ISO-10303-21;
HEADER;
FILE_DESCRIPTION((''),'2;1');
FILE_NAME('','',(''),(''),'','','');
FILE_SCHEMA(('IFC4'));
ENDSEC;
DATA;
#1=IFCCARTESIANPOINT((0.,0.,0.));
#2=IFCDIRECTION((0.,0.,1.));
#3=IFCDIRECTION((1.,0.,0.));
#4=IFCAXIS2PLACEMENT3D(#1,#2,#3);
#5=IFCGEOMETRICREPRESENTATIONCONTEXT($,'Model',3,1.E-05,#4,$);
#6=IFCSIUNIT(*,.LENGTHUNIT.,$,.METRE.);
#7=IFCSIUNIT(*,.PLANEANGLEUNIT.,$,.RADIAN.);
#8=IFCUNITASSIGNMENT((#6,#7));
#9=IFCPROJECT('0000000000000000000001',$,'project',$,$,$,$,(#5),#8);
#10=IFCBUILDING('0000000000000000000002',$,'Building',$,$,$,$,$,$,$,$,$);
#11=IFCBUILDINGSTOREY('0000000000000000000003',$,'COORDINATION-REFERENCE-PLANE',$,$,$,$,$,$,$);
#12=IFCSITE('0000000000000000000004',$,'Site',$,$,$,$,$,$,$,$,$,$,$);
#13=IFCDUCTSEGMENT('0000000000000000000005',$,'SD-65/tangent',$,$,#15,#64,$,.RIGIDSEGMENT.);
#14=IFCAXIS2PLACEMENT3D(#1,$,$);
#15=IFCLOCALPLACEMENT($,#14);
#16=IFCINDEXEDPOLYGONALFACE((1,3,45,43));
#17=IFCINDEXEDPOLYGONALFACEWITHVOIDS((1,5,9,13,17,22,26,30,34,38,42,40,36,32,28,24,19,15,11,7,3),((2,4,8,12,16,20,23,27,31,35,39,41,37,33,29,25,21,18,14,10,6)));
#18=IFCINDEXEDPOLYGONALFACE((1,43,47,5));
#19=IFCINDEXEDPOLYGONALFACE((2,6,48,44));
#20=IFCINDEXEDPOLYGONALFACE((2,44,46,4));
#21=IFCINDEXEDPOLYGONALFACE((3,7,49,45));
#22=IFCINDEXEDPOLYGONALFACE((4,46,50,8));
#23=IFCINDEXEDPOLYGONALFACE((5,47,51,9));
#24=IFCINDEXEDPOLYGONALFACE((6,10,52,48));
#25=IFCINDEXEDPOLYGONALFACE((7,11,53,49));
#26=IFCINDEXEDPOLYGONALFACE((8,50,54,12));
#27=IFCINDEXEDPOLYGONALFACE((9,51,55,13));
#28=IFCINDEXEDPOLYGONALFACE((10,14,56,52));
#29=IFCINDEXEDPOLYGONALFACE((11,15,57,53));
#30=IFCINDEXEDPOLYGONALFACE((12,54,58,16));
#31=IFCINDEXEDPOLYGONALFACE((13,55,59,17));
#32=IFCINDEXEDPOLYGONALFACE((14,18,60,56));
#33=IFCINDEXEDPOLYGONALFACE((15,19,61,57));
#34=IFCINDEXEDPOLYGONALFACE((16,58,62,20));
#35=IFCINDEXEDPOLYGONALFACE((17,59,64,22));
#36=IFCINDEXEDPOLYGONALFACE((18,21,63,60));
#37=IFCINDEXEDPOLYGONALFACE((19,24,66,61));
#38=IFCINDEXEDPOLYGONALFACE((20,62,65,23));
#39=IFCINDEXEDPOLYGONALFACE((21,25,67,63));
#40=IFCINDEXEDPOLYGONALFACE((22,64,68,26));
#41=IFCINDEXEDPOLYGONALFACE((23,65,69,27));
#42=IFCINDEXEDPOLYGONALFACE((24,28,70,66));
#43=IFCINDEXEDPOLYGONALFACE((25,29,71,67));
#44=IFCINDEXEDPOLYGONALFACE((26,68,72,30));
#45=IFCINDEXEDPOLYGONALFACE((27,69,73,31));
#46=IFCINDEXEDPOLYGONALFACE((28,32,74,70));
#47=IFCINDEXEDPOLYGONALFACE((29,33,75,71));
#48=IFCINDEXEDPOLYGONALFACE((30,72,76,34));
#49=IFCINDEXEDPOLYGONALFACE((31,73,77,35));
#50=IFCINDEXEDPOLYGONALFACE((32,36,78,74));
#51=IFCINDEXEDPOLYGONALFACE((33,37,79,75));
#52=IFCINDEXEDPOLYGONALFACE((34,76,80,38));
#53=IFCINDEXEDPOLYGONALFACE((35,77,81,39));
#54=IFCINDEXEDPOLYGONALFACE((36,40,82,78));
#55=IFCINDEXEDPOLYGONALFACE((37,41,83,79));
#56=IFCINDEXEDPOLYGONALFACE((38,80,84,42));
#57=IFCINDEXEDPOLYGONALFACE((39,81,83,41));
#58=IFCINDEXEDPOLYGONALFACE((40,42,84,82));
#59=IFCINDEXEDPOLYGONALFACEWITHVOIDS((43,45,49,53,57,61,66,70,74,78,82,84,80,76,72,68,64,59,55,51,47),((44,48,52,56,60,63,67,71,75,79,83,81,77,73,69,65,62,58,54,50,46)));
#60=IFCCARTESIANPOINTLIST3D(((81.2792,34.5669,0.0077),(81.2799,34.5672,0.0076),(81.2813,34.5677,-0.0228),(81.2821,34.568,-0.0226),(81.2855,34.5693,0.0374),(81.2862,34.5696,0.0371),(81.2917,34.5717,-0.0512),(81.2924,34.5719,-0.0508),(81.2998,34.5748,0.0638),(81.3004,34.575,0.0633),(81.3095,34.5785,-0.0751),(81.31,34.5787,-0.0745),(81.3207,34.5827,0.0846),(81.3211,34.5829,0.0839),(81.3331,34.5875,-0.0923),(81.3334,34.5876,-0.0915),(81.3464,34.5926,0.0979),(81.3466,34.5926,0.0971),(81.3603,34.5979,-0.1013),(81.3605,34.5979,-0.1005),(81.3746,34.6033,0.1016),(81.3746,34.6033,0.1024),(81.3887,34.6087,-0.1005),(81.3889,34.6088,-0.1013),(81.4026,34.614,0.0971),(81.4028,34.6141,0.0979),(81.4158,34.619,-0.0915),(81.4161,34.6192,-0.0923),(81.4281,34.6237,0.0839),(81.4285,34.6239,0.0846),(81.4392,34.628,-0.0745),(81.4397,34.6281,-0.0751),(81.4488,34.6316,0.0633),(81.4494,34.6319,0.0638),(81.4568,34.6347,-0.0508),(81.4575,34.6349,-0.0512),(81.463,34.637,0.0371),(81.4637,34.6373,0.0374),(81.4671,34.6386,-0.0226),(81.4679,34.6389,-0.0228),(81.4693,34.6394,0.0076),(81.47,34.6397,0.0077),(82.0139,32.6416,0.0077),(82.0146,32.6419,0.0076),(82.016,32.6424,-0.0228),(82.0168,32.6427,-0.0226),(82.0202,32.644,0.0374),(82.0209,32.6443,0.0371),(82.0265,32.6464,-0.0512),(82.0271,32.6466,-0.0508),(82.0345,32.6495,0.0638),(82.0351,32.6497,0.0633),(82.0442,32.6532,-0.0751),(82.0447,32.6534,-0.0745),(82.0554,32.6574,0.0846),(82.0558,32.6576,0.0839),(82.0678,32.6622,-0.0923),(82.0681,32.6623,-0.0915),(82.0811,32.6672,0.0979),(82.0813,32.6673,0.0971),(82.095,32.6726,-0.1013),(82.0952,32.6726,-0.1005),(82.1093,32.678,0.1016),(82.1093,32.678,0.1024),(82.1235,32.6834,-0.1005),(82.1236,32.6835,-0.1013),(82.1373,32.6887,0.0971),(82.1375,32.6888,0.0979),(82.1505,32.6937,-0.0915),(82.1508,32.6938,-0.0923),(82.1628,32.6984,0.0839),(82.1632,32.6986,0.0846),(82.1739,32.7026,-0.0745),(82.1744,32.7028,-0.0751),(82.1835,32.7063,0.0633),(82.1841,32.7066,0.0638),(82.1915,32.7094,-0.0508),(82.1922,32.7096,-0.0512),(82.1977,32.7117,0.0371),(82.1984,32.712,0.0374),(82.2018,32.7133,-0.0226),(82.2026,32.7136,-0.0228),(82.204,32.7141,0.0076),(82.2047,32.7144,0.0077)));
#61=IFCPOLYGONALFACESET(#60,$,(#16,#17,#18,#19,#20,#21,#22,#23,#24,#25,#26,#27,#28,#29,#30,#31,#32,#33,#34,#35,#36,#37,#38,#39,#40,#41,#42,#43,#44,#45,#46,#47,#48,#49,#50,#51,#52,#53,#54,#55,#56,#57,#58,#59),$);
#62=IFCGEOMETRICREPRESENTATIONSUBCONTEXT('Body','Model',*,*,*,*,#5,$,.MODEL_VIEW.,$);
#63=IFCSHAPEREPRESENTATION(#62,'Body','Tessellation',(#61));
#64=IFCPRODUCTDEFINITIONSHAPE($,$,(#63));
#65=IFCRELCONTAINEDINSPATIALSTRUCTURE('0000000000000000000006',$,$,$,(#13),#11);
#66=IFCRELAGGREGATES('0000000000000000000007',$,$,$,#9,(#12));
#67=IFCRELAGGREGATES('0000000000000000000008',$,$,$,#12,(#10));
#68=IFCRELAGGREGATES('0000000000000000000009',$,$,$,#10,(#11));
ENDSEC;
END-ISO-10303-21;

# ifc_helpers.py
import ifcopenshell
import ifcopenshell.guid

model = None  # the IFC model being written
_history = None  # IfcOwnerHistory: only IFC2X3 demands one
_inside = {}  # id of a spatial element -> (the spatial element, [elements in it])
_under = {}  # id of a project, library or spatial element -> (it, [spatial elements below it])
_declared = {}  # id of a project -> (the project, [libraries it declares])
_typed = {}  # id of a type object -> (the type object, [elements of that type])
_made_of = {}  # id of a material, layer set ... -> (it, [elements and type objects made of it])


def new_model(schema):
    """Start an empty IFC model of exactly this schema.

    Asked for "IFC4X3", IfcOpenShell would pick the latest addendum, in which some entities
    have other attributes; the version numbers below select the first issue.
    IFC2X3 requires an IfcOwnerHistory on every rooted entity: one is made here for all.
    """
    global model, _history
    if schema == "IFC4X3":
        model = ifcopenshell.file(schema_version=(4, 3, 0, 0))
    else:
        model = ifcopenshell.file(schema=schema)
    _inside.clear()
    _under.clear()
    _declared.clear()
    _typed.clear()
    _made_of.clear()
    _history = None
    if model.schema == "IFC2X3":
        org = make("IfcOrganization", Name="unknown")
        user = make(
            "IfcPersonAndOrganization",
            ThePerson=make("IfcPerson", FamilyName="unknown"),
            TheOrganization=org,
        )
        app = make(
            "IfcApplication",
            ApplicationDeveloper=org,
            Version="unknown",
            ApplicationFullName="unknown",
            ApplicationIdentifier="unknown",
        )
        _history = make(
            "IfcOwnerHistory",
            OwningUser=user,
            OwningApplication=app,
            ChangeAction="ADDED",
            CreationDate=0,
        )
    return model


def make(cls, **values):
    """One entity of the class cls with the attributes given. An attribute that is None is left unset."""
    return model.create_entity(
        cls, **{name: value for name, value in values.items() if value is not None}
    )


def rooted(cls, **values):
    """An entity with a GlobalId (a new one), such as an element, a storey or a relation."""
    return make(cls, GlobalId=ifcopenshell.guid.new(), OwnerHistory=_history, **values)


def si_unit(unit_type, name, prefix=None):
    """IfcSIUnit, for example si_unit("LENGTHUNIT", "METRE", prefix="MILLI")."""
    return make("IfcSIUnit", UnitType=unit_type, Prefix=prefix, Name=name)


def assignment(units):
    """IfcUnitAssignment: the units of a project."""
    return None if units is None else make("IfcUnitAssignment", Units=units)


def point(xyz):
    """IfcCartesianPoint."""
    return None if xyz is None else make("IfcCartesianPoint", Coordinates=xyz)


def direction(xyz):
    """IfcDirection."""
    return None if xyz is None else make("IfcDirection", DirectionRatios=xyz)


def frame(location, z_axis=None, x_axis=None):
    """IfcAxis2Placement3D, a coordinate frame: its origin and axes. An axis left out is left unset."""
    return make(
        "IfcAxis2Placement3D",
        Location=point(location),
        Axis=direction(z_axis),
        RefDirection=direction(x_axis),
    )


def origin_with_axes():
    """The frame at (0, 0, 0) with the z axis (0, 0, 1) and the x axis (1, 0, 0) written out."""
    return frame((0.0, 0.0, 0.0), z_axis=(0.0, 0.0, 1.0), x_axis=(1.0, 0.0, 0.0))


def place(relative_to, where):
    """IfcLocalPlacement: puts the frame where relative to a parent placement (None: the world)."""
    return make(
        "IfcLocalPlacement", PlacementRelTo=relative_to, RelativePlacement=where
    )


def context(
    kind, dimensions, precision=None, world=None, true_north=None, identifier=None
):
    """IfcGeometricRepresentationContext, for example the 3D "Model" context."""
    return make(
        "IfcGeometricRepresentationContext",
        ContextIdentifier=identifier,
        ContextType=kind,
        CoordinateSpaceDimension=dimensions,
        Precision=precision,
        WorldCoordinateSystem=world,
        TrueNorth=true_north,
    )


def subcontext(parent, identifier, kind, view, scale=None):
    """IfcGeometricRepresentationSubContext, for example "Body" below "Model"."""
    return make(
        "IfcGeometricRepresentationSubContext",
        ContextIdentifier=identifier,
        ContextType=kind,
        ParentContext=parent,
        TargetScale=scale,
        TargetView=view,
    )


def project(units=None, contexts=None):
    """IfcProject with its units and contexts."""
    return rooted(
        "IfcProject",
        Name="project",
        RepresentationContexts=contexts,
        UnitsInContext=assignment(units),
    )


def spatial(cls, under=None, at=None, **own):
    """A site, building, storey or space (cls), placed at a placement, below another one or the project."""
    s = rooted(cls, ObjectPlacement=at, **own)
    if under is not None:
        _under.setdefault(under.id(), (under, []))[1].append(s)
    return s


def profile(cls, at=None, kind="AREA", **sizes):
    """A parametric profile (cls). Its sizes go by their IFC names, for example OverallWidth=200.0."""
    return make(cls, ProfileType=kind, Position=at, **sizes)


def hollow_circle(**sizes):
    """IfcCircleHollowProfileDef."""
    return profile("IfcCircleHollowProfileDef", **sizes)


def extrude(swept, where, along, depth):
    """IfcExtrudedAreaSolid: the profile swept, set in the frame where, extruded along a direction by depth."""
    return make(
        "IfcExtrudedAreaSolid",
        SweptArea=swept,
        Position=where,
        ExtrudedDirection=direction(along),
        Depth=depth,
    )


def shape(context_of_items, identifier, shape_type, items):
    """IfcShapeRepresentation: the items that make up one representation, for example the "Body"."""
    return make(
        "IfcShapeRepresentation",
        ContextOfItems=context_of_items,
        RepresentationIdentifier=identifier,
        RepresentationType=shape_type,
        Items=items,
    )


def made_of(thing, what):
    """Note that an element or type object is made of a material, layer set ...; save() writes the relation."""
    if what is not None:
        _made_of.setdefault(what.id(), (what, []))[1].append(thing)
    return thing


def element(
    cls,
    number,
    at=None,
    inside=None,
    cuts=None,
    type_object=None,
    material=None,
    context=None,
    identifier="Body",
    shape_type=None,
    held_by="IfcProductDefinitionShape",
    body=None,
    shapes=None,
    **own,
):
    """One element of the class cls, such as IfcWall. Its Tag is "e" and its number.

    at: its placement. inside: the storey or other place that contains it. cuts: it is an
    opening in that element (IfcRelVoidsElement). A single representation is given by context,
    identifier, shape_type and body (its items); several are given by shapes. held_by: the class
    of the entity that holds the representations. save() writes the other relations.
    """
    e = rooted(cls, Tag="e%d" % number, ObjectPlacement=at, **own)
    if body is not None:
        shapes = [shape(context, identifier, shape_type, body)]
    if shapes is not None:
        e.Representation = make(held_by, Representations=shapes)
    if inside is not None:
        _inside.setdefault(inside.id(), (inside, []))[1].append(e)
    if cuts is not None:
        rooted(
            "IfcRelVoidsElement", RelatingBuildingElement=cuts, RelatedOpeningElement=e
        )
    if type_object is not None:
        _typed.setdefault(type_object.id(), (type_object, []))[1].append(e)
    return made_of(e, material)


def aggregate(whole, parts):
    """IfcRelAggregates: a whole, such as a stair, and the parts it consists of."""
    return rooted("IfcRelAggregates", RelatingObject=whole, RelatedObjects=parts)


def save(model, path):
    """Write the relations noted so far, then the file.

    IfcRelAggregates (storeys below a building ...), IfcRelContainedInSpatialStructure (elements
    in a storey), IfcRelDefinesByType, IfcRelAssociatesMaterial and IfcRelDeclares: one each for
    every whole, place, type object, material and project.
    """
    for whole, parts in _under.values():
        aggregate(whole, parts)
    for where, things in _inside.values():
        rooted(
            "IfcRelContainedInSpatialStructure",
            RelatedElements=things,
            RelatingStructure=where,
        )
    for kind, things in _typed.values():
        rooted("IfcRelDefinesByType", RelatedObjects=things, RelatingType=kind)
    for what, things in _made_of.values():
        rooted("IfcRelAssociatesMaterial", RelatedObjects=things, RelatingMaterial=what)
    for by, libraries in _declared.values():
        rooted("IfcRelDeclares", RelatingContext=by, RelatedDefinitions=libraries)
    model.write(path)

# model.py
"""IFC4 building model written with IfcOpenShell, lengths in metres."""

from ifc_helpers import new_model, si_unit, frame, origin_with_axes, place, context, subcontext, project, spatial, hollow_circle, extrude, element, save


model = new_model("IFC4")

# Units and contexts
model_context = context("Model", 3, precision=1e-05, world=origin_with_axes())
body_context_1 = subcontext(model_context, "Body", "Model", "MODEL_VIEW")
ifc_project = project(units=[si_unit("LENGTHUNIT", "METRE"), si_unit("PLANEANGLEUNIT", "RADIAN")], contexts=[model_context])

# Site, building, storey
site = spatial("IfcSite", under=ifc_project, Name="Site")
building = spatial("IfcBuilding", under=site, Name="Building")
storey = spatial("IfcBuildingStorey", under=building, Name="COORDINATION-REFERENCE-PLANE")

# Duct segment
duct_segment_1_placement = place(None, frame((82.1093, 32.678, 0.0), z_axis=(-0.356527, 0.934285, 0.0), x_axis=(0.0, 0.0, 1.0)))
element("IfcDuctSegment", 1, at=duct_segment_1_placement, inside=storey, Name="SD-65/tangent", PredefinedType="RIGIDSEGMENT", context=body_context_1, shape_type="SweptSolid", body=[
    extrude(hollow_circle(Radius=0.1024, WallThickness=0.0008), origin_with_axes(), (0.0, 0.0, 1.0), 2.0607),
])

save(model, "model.ifc")
